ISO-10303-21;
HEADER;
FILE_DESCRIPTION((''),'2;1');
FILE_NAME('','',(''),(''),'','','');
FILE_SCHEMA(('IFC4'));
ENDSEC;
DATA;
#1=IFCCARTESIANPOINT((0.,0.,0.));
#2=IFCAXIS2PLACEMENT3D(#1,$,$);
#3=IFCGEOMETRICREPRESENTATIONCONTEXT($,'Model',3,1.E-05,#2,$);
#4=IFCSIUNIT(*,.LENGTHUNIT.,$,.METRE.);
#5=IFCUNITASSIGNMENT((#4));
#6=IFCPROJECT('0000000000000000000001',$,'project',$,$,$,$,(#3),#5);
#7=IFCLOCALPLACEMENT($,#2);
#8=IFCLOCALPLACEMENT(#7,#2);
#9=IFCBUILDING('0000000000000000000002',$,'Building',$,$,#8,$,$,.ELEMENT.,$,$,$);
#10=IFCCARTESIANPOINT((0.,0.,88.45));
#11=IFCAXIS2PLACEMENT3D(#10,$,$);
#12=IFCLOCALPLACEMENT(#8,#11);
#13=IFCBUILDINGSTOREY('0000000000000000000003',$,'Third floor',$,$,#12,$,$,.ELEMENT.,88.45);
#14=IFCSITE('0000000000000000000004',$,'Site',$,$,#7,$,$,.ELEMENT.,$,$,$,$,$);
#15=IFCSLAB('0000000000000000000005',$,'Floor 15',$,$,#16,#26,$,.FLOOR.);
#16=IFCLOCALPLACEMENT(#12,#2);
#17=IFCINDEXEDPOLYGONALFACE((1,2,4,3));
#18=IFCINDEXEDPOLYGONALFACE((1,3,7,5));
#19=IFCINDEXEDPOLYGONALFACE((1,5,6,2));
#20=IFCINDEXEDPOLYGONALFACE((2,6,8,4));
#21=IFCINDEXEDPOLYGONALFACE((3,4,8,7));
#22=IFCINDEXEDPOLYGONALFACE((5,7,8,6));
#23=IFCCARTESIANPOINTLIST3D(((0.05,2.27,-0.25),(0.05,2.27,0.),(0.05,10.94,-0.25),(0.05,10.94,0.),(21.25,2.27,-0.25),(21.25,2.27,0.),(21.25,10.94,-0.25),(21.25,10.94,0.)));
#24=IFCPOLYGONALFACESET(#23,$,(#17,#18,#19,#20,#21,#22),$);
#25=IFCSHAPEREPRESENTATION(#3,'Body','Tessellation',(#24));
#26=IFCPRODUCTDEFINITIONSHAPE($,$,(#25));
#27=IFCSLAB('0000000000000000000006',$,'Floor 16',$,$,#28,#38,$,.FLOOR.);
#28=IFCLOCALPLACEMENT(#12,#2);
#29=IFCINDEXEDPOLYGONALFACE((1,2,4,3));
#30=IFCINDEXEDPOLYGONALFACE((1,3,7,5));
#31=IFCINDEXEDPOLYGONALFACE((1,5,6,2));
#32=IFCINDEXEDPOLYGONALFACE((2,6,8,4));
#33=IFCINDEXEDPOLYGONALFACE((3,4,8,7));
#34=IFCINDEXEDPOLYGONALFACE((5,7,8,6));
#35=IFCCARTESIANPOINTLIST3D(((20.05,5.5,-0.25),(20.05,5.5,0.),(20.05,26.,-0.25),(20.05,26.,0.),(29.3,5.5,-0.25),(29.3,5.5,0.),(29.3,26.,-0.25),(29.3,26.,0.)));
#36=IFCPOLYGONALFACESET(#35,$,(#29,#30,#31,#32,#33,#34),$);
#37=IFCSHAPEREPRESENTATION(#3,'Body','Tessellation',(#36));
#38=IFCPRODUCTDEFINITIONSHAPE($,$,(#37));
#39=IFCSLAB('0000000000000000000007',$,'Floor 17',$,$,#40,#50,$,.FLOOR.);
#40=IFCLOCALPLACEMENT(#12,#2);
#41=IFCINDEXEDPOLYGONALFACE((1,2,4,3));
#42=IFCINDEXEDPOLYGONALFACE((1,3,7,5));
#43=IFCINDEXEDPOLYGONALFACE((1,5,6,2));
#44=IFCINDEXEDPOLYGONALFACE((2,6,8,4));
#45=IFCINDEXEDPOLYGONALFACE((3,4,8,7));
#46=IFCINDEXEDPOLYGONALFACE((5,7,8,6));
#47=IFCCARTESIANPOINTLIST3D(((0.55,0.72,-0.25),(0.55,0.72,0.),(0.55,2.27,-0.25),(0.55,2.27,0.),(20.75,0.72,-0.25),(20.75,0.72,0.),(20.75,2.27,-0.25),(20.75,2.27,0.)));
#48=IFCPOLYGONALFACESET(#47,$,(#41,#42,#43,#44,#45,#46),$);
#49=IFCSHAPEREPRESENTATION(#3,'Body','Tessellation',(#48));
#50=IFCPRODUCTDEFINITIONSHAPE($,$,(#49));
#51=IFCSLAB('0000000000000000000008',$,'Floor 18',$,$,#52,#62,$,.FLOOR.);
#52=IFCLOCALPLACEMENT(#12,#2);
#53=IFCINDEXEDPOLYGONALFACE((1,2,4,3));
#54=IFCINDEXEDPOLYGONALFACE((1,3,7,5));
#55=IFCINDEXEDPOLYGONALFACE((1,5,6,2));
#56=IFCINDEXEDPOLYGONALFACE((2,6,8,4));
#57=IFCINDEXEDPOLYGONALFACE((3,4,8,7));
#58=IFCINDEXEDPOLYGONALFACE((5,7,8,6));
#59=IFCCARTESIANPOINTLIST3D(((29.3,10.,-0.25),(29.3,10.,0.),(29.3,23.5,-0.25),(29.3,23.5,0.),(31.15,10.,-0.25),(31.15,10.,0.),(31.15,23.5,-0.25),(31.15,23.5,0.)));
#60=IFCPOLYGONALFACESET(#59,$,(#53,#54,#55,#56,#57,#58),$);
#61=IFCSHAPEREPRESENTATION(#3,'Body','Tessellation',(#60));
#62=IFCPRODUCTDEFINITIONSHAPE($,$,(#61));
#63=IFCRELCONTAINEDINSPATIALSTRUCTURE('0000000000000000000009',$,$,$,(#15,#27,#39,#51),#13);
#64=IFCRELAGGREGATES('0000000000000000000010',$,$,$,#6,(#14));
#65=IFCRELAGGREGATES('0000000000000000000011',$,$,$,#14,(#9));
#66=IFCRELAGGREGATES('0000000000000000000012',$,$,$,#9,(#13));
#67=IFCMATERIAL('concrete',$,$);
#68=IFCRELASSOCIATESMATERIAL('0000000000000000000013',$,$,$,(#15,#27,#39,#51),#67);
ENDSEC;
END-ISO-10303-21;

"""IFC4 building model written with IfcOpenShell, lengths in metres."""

from ifc_helpers import new_model, si_unit, frame, origin, place, context, project, spatial, polyline, outline, extrude, material, element, save


model = new_model("IFC4")

# Units and contexts
model_context = context("Model", 3, precision=1e-05, world=origin())
ifc_project = project(units=[si_unit("LENGTHUNIT", "METRE")], contexts=[model_context])

# Site, building, storey
site_placement = place(None, origin())
site = spatial("IfcSite", under=ifc_project, at=site_placement, Name="Site", CompositionType="ELEMENT")
building_placement = place(site_placement, origin())
building = spatial("IfcBuilding", under=site, at=building_placement, Name="Building", CompositionType="ELEMENT")
storey_placement = place(building_placement, frame((0.0, 0.0, 88.45)))
storey = spatial("IfcBuildingStorey", under=building, at=storey_placement, Name="Third floor", CompositionType="ELEMENT", Elevation=88.45)

# Slabs
ifc_material = material(Name="concrete")
slab_1_placement = place(storey_placement, frame((0.0, 0.0, -0.25), z_axis=(0.0, 0.0, 1.0), x_axis=(1.0, 0.0, 0.0)))
element("IfcSlab", 1, at=slab_1_placement, inside=storey, material=ifc_material, Name="Floor 15", PredefinedType="FLOOR", context=model_context, shape_type="SweptSolid", body=[
    extrude(outline(polyline([(0.05, 2.27), (21.25, 2.27), (21.25, 10.94), (0.05, 10.94), (0.05, 2.27)])), origin(), (0.0, 0.0, 1.0), 0.25),
])
slab_2_placement = place(storey_placement, frame((0.0, 0.0, -0.25), z_axis=(0.0, 0.0, 1.0), x_axis=(1.0, 0.0, 0.0)))
element("IfcSlab", 2, at=slab_2_placement, inside=storey, material=ifc_material, Name="Floor 16", PredefinedType="FLOOR", context=model_context, shape_type="SweptSolid", body=[
    extrude(outline(polyline([(20.05, 5.5), (29.3, 5.5), (29.3, 26.0), (20.05, 26.0), (20.05, 5.5)])), origin(), (0.0, 0.0, 1.0), 0.25),
])
slab_3_placement = place(storey_placement, frame((0.0, 0.0, -0.25), z_axis=(0.0, 0.0, 1.0), x_axis=(1.0, 0.0, 0.0)))
element("IfcSlab", 3, at=slab_3_placement, inside=storey, material=ifc_material, Name="Floor 17", PredefinedType="FLOOR", context=model_context, shape_type="SweptSolid", body=[
    extrude(outline(polyline([(0.55, 0.72), (20.75, 0.72), (20.75, 2.27), (0.55, 2.27), (0.55, 0.72)])), origin(), (0.0, 0.0, 1.0), 0.25),
])
slab_4_placement = place(storey_placement, frame((0.0, 0.0, -0.25), z_axis=(0.0, 0.0, 1.0), x_axis=(1.0, 0.0, 0.0)))
element("IfcSlab", 4, at=slab_4_placement, inside=storey, material=ifc_material, Name="Floor 18", PredefinedType="FLOOR", context=model_context, shape_type="SweptSolid", body=[
    extrude(outline(polyline([(29.3, 10.0), (31.15, 10.0), (31.15, 23.5), (29.3, 23.5), (29.3, 10.0)])), origin(), (0.0, 0.0, 1.0), 0.25),
])

save(model, "model.ifc")
